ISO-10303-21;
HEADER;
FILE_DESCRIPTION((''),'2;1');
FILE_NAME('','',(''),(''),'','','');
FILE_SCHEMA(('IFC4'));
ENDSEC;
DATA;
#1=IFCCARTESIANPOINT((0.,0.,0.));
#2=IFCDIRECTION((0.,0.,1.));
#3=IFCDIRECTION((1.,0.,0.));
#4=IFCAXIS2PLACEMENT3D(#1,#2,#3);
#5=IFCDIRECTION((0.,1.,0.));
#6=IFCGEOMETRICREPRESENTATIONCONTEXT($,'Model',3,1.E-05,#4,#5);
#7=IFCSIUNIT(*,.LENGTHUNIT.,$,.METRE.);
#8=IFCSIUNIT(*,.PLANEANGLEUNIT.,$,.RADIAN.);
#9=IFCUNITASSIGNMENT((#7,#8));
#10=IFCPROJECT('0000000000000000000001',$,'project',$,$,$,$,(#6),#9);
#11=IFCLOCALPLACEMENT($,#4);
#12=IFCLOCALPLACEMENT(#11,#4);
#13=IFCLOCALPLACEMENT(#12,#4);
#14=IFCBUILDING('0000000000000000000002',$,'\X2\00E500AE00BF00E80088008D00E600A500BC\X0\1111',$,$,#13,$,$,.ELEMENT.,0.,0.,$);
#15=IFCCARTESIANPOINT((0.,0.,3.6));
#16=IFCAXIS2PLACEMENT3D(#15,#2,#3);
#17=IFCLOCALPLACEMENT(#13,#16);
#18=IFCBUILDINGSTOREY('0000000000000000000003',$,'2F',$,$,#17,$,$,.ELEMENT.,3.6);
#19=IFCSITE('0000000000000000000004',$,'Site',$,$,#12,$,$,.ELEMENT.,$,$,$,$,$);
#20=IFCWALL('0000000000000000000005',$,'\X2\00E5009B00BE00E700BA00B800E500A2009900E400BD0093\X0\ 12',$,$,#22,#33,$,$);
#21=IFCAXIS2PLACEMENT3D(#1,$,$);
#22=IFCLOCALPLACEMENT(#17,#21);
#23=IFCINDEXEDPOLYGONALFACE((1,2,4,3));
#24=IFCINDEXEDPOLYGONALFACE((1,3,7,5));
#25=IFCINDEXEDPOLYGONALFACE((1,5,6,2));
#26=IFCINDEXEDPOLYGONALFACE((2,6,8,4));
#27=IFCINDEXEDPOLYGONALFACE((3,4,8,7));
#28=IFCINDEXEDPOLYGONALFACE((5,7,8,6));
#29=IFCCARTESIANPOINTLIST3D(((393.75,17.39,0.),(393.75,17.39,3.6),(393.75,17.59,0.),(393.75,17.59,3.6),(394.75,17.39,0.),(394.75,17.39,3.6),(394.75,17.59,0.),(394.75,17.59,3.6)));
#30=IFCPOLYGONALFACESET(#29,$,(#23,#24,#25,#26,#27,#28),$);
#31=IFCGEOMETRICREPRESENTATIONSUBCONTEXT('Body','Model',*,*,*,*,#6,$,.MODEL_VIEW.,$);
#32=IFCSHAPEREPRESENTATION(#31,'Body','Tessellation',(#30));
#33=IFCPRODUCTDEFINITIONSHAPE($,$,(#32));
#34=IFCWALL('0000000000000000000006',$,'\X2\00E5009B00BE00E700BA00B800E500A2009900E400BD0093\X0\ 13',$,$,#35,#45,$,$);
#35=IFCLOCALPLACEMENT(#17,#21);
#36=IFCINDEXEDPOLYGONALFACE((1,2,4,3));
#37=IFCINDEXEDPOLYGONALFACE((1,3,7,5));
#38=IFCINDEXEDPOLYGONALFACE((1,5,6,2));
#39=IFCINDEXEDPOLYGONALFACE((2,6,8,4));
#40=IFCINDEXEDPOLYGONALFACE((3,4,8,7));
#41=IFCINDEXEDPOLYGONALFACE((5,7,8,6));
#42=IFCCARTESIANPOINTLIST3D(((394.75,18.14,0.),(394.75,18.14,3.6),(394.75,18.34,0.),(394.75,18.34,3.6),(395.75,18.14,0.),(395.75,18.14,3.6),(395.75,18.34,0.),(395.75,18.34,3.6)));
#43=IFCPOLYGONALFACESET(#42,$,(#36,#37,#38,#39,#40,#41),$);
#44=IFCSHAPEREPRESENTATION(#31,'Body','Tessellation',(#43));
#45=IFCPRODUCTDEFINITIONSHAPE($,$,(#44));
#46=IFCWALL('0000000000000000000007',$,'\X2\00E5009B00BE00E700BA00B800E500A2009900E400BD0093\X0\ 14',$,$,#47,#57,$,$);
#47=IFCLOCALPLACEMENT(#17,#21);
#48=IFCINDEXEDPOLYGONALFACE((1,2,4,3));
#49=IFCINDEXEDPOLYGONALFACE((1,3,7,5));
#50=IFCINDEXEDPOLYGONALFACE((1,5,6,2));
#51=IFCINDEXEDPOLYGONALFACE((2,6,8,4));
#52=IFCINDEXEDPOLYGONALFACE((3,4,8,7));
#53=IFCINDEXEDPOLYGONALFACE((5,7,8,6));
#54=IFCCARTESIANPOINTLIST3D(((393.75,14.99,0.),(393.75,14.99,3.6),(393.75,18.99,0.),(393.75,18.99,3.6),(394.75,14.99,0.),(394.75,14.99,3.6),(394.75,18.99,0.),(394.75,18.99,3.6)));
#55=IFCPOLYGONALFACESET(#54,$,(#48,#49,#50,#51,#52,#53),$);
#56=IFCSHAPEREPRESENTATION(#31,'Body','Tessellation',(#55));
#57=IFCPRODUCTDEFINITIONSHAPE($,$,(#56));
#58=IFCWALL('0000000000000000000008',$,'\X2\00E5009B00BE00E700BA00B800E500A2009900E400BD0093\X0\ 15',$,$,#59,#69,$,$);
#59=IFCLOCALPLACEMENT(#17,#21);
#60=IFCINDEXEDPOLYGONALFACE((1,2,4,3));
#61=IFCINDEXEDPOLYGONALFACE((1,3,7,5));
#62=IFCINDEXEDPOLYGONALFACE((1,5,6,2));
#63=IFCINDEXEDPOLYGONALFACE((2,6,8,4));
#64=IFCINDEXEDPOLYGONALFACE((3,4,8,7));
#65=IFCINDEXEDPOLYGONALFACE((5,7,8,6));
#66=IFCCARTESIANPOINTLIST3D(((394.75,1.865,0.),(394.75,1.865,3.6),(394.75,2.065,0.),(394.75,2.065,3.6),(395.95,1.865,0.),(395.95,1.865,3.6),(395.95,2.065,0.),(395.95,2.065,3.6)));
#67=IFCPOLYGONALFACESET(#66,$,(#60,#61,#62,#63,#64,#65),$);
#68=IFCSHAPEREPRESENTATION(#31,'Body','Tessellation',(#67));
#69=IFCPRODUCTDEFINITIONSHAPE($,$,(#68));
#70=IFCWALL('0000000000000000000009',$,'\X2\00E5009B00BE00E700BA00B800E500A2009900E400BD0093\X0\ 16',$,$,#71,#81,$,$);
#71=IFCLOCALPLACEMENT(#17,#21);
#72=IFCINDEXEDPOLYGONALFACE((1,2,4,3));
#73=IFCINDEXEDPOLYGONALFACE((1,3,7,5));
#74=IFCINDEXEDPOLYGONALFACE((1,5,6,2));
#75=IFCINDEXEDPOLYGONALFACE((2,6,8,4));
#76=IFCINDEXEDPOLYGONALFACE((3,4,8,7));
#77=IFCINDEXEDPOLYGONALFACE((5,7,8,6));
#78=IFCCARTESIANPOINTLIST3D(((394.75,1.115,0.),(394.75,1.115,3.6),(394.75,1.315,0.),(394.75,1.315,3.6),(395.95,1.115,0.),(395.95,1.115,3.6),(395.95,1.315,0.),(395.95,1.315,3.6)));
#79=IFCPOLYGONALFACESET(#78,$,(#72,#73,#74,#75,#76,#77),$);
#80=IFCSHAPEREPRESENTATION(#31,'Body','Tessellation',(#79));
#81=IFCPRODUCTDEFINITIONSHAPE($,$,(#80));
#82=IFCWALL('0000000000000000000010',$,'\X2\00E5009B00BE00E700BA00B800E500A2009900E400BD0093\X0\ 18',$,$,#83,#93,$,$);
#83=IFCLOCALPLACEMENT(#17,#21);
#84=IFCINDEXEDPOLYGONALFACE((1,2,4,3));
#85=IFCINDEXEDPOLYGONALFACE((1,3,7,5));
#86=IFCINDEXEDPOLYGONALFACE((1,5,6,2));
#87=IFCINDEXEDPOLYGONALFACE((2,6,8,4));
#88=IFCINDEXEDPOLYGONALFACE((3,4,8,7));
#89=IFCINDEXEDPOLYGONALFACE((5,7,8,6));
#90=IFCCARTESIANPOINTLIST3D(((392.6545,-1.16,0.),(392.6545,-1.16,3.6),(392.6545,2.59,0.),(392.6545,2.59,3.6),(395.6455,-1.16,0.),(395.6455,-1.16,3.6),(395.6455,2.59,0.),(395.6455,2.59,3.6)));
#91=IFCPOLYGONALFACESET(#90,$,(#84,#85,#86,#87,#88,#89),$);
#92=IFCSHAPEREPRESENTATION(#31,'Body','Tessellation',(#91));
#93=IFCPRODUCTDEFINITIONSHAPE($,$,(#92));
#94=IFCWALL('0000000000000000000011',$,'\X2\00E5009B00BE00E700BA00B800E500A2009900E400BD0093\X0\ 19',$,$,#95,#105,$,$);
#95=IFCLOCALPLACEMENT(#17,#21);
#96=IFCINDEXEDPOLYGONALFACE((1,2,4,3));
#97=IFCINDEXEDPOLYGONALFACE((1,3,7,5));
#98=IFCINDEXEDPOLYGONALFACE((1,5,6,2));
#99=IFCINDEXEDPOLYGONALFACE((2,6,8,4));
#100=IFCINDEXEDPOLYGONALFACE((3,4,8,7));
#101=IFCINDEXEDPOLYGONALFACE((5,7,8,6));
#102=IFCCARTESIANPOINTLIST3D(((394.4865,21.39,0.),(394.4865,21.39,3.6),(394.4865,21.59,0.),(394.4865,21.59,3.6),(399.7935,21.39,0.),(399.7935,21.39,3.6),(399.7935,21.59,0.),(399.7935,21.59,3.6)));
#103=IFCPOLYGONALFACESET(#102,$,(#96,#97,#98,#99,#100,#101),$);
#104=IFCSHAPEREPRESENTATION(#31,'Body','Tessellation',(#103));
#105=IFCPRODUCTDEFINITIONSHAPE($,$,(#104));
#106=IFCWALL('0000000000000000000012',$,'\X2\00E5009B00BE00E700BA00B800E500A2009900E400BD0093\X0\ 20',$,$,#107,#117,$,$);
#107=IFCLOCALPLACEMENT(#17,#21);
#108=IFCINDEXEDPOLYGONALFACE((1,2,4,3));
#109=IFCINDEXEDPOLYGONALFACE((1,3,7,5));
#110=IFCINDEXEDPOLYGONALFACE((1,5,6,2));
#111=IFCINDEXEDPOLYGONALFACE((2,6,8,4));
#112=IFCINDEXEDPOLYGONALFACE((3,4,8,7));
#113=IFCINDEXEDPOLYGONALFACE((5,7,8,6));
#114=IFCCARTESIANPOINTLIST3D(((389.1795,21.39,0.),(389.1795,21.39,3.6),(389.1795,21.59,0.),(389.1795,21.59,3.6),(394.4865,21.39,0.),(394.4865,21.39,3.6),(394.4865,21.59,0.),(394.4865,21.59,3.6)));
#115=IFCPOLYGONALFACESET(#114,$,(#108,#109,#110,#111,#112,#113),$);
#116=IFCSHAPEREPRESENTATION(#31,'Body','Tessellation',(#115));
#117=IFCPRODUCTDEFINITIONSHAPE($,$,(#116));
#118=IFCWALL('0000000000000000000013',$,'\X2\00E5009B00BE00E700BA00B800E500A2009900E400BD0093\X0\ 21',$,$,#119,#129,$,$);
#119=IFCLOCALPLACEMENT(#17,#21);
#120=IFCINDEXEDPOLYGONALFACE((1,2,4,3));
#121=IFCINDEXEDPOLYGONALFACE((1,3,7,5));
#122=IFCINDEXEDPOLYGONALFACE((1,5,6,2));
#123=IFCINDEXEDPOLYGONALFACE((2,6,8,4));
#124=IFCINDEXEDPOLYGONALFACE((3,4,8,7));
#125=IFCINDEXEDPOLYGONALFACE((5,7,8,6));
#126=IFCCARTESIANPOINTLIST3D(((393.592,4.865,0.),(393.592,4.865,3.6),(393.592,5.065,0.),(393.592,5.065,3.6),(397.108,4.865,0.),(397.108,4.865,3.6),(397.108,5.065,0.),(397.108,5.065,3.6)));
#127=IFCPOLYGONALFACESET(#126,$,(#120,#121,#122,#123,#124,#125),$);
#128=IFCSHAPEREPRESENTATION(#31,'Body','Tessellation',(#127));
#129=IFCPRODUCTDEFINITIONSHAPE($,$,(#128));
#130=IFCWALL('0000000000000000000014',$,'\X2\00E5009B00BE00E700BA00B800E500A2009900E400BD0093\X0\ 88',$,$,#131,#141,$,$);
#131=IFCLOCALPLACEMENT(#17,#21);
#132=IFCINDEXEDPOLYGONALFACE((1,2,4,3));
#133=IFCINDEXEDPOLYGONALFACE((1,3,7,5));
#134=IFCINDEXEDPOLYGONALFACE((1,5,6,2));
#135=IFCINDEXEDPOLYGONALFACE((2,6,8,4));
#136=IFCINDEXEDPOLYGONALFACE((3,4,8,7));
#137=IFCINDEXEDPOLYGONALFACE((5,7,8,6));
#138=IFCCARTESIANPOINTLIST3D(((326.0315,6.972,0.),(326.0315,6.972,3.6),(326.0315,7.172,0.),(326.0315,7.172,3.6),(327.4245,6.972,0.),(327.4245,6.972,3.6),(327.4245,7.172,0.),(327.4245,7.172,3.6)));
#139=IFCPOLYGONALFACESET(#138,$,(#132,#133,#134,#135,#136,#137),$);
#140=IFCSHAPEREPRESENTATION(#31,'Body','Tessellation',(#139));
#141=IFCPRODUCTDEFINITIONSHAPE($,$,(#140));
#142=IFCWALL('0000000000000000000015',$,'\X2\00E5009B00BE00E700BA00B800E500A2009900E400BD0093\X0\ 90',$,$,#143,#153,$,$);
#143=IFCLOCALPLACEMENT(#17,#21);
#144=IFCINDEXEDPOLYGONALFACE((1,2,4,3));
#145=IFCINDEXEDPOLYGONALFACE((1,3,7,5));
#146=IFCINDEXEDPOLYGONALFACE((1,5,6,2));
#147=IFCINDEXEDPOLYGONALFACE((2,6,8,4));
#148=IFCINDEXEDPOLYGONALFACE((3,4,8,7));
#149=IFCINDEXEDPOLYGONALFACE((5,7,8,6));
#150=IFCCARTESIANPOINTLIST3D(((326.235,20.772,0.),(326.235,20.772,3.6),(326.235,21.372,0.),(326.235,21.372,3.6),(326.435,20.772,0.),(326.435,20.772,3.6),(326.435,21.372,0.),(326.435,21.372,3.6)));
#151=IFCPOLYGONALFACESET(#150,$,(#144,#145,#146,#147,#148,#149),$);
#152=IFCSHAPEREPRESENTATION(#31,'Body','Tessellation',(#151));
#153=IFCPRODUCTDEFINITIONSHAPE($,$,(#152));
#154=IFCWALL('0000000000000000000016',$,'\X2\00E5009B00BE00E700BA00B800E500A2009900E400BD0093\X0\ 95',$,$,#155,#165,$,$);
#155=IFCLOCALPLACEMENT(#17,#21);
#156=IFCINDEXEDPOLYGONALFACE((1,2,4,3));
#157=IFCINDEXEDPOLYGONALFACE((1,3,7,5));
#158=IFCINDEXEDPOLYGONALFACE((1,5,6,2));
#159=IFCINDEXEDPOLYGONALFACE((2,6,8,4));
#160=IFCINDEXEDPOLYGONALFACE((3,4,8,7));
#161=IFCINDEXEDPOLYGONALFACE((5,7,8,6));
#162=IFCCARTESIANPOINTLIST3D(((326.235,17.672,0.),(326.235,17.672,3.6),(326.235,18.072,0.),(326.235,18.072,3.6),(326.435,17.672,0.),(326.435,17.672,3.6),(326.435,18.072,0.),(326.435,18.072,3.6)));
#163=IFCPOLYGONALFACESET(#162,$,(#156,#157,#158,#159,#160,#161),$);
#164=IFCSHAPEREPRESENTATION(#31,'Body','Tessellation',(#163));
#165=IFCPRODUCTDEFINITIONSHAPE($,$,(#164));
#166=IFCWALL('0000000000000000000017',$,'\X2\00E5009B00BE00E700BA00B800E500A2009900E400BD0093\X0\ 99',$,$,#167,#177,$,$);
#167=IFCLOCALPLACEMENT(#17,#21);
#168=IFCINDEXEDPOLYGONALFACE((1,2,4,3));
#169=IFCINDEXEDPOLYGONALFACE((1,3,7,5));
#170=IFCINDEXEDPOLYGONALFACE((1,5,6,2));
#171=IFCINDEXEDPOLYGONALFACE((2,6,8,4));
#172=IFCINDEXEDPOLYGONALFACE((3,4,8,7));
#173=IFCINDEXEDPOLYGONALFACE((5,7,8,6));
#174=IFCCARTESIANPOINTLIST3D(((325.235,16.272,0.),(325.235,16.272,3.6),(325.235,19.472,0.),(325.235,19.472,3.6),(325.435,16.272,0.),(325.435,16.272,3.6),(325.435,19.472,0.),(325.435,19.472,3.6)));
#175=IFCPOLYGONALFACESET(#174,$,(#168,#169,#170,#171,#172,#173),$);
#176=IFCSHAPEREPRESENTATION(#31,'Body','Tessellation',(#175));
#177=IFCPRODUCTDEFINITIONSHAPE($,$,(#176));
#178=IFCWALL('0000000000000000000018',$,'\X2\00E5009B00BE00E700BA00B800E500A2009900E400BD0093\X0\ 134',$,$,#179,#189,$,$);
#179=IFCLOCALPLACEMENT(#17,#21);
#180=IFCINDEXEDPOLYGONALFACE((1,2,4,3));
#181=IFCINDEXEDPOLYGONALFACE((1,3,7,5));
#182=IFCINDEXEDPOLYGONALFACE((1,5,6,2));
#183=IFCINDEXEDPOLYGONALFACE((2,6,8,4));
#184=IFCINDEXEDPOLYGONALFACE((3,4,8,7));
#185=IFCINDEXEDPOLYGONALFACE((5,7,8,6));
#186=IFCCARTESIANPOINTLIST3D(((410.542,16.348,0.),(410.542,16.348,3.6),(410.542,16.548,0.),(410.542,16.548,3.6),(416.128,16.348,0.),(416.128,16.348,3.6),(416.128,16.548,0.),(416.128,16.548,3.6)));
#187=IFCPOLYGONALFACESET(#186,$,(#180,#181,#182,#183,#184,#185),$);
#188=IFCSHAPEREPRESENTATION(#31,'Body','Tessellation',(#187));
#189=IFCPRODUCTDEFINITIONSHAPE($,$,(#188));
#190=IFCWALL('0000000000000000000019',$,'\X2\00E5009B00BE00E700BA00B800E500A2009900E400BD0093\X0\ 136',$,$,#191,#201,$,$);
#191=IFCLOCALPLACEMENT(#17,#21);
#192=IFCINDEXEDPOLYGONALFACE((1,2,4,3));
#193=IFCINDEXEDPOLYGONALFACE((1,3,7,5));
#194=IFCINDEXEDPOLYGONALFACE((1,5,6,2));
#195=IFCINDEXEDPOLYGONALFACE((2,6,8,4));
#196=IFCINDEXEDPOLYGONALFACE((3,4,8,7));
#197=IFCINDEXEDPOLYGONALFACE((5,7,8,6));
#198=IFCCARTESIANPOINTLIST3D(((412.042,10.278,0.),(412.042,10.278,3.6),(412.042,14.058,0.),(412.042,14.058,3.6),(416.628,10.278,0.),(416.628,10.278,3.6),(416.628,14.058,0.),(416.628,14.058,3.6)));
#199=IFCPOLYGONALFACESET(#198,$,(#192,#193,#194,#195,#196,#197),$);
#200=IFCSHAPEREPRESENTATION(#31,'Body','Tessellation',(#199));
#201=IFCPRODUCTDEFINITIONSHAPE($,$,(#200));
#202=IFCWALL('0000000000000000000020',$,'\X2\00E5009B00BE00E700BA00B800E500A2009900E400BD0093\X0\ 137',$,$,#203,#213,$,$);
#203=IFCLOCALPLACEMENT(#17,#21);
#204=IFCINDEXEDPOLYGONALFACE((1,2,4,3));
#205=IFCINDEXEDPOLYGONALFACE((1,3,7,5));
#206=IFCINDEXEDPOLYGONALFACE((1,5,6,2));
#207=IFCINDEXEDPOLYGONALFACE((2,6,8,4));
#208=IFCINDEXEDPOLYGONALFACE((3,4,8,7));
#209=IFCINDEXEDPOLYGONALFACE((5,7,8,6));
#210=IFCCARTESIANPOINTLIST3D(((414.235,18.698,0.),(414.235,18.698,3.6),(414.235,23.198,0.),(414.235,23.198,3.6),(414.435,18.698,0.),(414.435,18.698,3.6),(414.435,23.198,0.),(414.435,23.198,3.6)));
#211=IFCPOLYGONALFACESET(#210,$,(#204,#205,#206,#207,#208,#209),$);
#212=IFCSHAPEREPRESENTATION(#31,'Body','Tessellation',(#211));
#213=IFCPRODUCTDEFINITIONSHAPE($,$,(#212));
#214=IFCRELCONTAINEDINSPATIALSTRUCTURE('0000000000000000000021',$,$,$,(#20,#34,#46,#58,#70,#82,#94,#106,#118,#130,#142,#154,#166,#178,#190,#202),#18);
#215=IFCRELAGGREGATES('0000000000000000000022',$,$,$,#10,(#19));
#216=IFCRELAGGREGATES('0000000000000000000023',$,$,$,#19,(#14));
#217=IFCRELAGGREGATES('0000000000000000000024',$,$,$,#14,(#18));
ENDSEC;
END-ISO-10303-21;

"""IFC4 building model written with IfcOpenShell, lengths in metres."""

from ifc_helpers import new_model, si_unit, direction, frame, frame_2d, origin_with_axes, place, context, subcontext, project, spatial, rectangle, extrude, element, save


model = new_model("IFC4")

# Units and contexts
model_context = context("Model", 3, precision=1e-05, world=origin_with_axes(), true_north=direction((0.0, 1.0, 0.0)))
body_context = subcontext(model_context, "Body", "Model", "MODEL_VIEW")
ifc_project = project(units=[si_unit("LENGTHUNIT", "METRE"), si_unit("PLANEANGLEUNIT", "RADIAN")], contexts=[model_context])

# Site, building, storey
placement = place(None, origin_with_axes())
site_placement = place(placement, origin_with_axes())
site = spatial("IfcSite", under=ifc_project, at=site_placement, Name="Site", CompositionType="ELEMENT")
building_placement = place(site_placement, origin_with_axes())
building = spatial("IfcBuilding", under=site, at=building_placement, Name="å®¿è\u0088\u008dæ¥¼1111", CompositionType="ELEMENT", ElevationOfRefHeight=0.0, ElevationOfTerrain=0.0)
storey_placement = place(building_placement, frame((0.0, 0.0, 3.6), z_axis=(0.0, 0.0, 1.0), x_axis=(1.0, 0.0, 0.0)))
storey = spatial("IfcBuildingStorey", under=building, at=storey_placement, Name="2F", CompositionType="ELEMENT", Elevation=3.6)

# Walls
for number, where, z_axis, x_axis, name in (
    (1, (394.25, 17.49, 0.0), (0.0, 0.0, 1.0), (1.0, 0.0, 0.0), "å\u009b¾çº¸å¢\u0099ä½\u0093 12"),
    (2, (395.25, 18.24, 0.0), (0.0, 0.0, 1.0), (-1.0, 0.0, 0.0), "å\u009b¾çº¸å¢\u0099ä½\u0093 13"),
):
    element("IfcWall", number, at=place(storey_placement, frame(where, z_axis=z_axis, x_axis=x_axis)), inside=storey, Name=name, context=body_context, shape_type="SweptSolid", body=[
        extrude(rectangle(XDim=1.0, YDim=0.2, at=frame_2d((0.0, 0.0), x_axis=(1.0, 0.0, 0.0))), frame((0.0, 0.0, 0.0), z_axis=(0.0, 0.0, 1.0)), (0.0, 0.0, 1.0), 3.6),
    ])
wall_1_placement = place(storey_placement, frame((394.25, 16.99, 0.0), z_axis=(0.0, 0.0, 1.0), x_axis=(1.0, 0.0, 0.0)))
element("IfcWall", 3, at=wall_1_placement, inside=storey, Name="å\u009b¾çº¸å¢\u0099ä½\u0093 14", context=body_context, shape_type="SweptSolid", body=[
    extrude(rectangle(XDim=1.0, YDim=4.0, at=frame_2d((0.0, 0.0), x_axis=(1.0, 0.0, 0.0))), frame((0.0, 0.0, 0.0), z_axis=(0.0, 0.0, 1.0)), (0.0, 0.0, 1.0), 3.6),
])
for number, where, z_axis, x_axis, name in (
    (4, (395.35, 1.965, 0.0), (0.0, 0.0, 1.0), (-1.0, 0.0, 0.0), "å\u009b¾çº¸å¢\u0099ä½\u0093 15"),
    (5, (395.35, 1.215, 0.0), (0.0, 0.0, 1.0), (-1.0, 0.0, 0.0), "å\u009b¾çº¸å¢\u0099ä½\u0093 16"),
):
    element("IfcWall", number, at=place(storey_placement, frame(where, z_axis=z_axis, x_axis=x_axis)), inside=storey, Name=name, context=body_context, shape_type="SweptSolid", body=[
        extrude(rectangle(XDim=1.2, YDim=0.2, at=frame_2d((0.0, 0.0), x_axis=(1.0, 0.0, 0.0))), frame((0.0, 0.0, 0.0), z_axis=(0.0, 0.0, 1.0)), (0.0, 0.0, 1.0), 3.6),
    ])
wall_2_placement = place(storey_placement, frame((394.15, 0.715, 0.0), z_axis=(0.0, 0.0, 1.0), x_axis=(1.0, 0.0, 0.0)))
element("IfcWall", 6, at=wall_2_placement, inside=storey, Name="å\u009b¾çº¸å¢\u0099ä½\u0093 18", context=body_context, shape_type="SweptSolid", body=[
    extrude(rectangle(XDim=2.991, YDim=3.75, at=frame_2d((0.0, 0.0), x_axis=(1.0, 0.0, 0.0))), frame((0.0, 0.0, 0.0), z_axis=(0.0, 0.0, 1.0)), (0.0, 0.0, 1.0), 3.6),
])
for number, where, z_axis, x_axis, name in (
    (7, (397.14, 21.49, 0.0), (0.0, 0.0, 1.0), (-1.0, 0.0, 0.0), "å\u009b¾çº¸å¢\u0099ä½\u0093 19"),
    (8, (391.833, 21.49, 0.0), (0.0, 0.0, 1.0), (1.0, 0.0, 0.0), "å\u009b¾çº¸å¢\u0099ä½\u0093 20"),
):
    element("IfcWall", number, at=place(storey_placement, frame(where, z_axis=z_axis, x_axis=x_axis)), inside=storey, Name=name, context=body_context, shape_type="SweptSolid", body=[
        extrude(rectangle(XDim=5.307, YDim=0.2, at=frame_2d((0.0, 0.0), x_axis=(1.0, 0.0, 0.0))), frame((0.0, 0.0, 0.0), z_axis=(0.0, 0.0, 1.0)), (0.0, 0.0, 1.0), 3.6),
    ])
wall_3_placement = place(storey_placement, frame((395.35, 4.965, 0.0), z_axis=(0.0, 0.0, 1.0), x_axis=(-1.0, 0.0, 0.0)))
element("IfcWall", 9, at=wall_3_placement, inside=storey, Name="å\u009b¾çº¸å¢\u0099ä½\u0093 21", context=body_context, shape_type="SweptSolid", body=[
    extrude(rectangle(XDim=3.516, YDim=0.2, at=frame_2d((0.0, 0.0), x_axis=(1.0, 0.0, 0.0))), frame((0.0, 0.0, 0.0), z_axis=(0.0, 0.0, 1.0)), (0.0, 0.0, 1.0), 3.6),
])
wall_4_placement = place(storey_placement, frame((326.728, 7.072, 0.0), z_axis=(0.0, 0.0, 1.0), x_axis=(-1.0, 0.0, 0.0)))
element("IfcWall", 10, at=wall_4_placement, inside=storey, Name="å\u009b¾çº¸å¢\u0099ä½\u0093 88", context=body_context, shape_type="SweptSolid", body=[
    extrude(rectangle(XDim=1.393, YDim=0.2, at=frame_2d((0.0, 0.0), x_axis=(1.0, 0.0, 0.0))), frame((0.0, 0.0, 0.0), z_axis=(0.0, 0.0, 1.0)), (0.0, 0.0, 1.0), 3.6),
])
wall_5_placement = place(storey_placement, frame((326.335, 21.072, 0.0), z_axis=(0.0, 0.0, 1.0), x_axis=(0.0, 1.0, 0.0)))
element("IfcWall", 11, at=wall_5_placement, inside=storey, Name="å\u009b¾çº¸å¢\u0099ä½\u0093 90", context=body_context, shape_type="SweptSolid", body=[
    extrude(rectangle(XDim=0.6, YDim=0.2, at=frame_2d((0.0, 0.0), x_axis=(1.0, 0.0, 0.0))), frame((0.0, 0.0, 0.0), z_axis=(0.0, 0.0, 1.0)), (0.0, 0.0, 1.0), 3.6),
])
wall_6_placement = place(storey_placement, frame((326.335, 17.872, 0.0), z_axis=(0.0, 0.0, 1.0), x_axis=(0.0, -1.0, 0.0)))
element("IfcWall", 12, at=wall_6_placement, inside=storey, Name="å\u009b¾çº¸å¢\u0099ä½\u0093 95", context=body_context, shape_type="SweptSolid", body=[
    extrude(rectangle(XDim=0.4, YDim=0.2, at=frame_2d((0.0, 0.0), x_axis=(1.0, 0.0, 0.0))), frame((0.0, 0.0, 0.0), z_axis=(0.0, 0.0, 1.0)), (0.0, 0.0, 1.0), 3.6),
])
wall_7_placement = place(storey_placement, frame((325.335, 17.872, 0.0), z_axis=(0.0, 0.0, 1.0), x_axis=(0.0, 1.0, 0.0)))
element("IfcWall", 13, at=wall_7_placement, inside=storey, Name="å\u009b¾çº¸å¢\u0099ä½\u0093 99", context=body_context, shape_type="SweptSolid", body=[
    extrude(rectangle(XDim=3.2, YDim=0.2, at=frame_2d((0.0, 0.0), x_axis=(1.0, 0.0, 0.0))), frame((0.0, 0.0, 0.0), z_axis=(0.0, 0.0, 1.0)), (0.0, 0.0, 1.0), 3.6),
])
wall_8_placement = place(storey_placement, frame((413.335, 16.448, 0.0), z_axis=(0.0, 0.0, 1.0), x_axis=(1.0, 0.0, 0.0)))
element("IfcWall", 14, at=wall_8_placement, inside=storey, Name="å\u009b¾çº¸å¢\u0099ä½\u0093 134", context=body_context, shape_type="SweptSolid", body=[
    extrude(rectangle(XDim=5.586, YDim=0.2, at=frame_2d((0.0, 0.0), x_axis=(1.0, 0.0, 0.0))), frame((0.0, 0.0, 0.0), z_axis=(0.0, 0.0, 1.0)), (0.0, 0.0, 1.0), 3.6),
])
wall_9_placement = place(storey_placement, frame((414.335, 12.168, 0.0), z_axis=(0.0, 0.0, 1.0), x_axis=(1.0, 0.0, 0.0)))
element("IfcWall", 15, at=wall_9_placement, inside=storey, Name="å\u009b¾çº¸å¢\u0099ä½\u0093 136", context=body_context, shape_type="SweptSolid", body=[
    extrude(rectangle(XDim=4.586, YDim=3.78, at=frame_2d((0.0, 0.0), x_axis=(1.0, 0.0, 0.0))), frame((0.0, 0.0, 0.0), z_axis=(0.0, 0.0, 1.0)), (0.0, 0.0, 1.0), 3.6),
])
wall_10_placement = place(storey_placement, frame((414.335, 20.948, 0.0), z_axis=(0.0, 0.0, 1.0), x_axis=(0.0, -1.0, 0.0)))
element("IfcWall", 16, at=wall_10_placement, inside=storey, Name="å\u009b¾çº¸å¢\u0099ä½\u0093 137", context=body_context, shape_type="SweptSolid", body=[
    extrude(rectangle(XDim=4.5, YDim=0.2, at=frame_2d((0.0, 0.0), x_axis=(1.0, 0.0, 0.0))), frame((0.0, 0.0, 0.0), z_axis=(0.0, 0.0, 1.0)), (0.0, 0.0, 1.0), 3.6),
])

save(model, "model.ifc")
